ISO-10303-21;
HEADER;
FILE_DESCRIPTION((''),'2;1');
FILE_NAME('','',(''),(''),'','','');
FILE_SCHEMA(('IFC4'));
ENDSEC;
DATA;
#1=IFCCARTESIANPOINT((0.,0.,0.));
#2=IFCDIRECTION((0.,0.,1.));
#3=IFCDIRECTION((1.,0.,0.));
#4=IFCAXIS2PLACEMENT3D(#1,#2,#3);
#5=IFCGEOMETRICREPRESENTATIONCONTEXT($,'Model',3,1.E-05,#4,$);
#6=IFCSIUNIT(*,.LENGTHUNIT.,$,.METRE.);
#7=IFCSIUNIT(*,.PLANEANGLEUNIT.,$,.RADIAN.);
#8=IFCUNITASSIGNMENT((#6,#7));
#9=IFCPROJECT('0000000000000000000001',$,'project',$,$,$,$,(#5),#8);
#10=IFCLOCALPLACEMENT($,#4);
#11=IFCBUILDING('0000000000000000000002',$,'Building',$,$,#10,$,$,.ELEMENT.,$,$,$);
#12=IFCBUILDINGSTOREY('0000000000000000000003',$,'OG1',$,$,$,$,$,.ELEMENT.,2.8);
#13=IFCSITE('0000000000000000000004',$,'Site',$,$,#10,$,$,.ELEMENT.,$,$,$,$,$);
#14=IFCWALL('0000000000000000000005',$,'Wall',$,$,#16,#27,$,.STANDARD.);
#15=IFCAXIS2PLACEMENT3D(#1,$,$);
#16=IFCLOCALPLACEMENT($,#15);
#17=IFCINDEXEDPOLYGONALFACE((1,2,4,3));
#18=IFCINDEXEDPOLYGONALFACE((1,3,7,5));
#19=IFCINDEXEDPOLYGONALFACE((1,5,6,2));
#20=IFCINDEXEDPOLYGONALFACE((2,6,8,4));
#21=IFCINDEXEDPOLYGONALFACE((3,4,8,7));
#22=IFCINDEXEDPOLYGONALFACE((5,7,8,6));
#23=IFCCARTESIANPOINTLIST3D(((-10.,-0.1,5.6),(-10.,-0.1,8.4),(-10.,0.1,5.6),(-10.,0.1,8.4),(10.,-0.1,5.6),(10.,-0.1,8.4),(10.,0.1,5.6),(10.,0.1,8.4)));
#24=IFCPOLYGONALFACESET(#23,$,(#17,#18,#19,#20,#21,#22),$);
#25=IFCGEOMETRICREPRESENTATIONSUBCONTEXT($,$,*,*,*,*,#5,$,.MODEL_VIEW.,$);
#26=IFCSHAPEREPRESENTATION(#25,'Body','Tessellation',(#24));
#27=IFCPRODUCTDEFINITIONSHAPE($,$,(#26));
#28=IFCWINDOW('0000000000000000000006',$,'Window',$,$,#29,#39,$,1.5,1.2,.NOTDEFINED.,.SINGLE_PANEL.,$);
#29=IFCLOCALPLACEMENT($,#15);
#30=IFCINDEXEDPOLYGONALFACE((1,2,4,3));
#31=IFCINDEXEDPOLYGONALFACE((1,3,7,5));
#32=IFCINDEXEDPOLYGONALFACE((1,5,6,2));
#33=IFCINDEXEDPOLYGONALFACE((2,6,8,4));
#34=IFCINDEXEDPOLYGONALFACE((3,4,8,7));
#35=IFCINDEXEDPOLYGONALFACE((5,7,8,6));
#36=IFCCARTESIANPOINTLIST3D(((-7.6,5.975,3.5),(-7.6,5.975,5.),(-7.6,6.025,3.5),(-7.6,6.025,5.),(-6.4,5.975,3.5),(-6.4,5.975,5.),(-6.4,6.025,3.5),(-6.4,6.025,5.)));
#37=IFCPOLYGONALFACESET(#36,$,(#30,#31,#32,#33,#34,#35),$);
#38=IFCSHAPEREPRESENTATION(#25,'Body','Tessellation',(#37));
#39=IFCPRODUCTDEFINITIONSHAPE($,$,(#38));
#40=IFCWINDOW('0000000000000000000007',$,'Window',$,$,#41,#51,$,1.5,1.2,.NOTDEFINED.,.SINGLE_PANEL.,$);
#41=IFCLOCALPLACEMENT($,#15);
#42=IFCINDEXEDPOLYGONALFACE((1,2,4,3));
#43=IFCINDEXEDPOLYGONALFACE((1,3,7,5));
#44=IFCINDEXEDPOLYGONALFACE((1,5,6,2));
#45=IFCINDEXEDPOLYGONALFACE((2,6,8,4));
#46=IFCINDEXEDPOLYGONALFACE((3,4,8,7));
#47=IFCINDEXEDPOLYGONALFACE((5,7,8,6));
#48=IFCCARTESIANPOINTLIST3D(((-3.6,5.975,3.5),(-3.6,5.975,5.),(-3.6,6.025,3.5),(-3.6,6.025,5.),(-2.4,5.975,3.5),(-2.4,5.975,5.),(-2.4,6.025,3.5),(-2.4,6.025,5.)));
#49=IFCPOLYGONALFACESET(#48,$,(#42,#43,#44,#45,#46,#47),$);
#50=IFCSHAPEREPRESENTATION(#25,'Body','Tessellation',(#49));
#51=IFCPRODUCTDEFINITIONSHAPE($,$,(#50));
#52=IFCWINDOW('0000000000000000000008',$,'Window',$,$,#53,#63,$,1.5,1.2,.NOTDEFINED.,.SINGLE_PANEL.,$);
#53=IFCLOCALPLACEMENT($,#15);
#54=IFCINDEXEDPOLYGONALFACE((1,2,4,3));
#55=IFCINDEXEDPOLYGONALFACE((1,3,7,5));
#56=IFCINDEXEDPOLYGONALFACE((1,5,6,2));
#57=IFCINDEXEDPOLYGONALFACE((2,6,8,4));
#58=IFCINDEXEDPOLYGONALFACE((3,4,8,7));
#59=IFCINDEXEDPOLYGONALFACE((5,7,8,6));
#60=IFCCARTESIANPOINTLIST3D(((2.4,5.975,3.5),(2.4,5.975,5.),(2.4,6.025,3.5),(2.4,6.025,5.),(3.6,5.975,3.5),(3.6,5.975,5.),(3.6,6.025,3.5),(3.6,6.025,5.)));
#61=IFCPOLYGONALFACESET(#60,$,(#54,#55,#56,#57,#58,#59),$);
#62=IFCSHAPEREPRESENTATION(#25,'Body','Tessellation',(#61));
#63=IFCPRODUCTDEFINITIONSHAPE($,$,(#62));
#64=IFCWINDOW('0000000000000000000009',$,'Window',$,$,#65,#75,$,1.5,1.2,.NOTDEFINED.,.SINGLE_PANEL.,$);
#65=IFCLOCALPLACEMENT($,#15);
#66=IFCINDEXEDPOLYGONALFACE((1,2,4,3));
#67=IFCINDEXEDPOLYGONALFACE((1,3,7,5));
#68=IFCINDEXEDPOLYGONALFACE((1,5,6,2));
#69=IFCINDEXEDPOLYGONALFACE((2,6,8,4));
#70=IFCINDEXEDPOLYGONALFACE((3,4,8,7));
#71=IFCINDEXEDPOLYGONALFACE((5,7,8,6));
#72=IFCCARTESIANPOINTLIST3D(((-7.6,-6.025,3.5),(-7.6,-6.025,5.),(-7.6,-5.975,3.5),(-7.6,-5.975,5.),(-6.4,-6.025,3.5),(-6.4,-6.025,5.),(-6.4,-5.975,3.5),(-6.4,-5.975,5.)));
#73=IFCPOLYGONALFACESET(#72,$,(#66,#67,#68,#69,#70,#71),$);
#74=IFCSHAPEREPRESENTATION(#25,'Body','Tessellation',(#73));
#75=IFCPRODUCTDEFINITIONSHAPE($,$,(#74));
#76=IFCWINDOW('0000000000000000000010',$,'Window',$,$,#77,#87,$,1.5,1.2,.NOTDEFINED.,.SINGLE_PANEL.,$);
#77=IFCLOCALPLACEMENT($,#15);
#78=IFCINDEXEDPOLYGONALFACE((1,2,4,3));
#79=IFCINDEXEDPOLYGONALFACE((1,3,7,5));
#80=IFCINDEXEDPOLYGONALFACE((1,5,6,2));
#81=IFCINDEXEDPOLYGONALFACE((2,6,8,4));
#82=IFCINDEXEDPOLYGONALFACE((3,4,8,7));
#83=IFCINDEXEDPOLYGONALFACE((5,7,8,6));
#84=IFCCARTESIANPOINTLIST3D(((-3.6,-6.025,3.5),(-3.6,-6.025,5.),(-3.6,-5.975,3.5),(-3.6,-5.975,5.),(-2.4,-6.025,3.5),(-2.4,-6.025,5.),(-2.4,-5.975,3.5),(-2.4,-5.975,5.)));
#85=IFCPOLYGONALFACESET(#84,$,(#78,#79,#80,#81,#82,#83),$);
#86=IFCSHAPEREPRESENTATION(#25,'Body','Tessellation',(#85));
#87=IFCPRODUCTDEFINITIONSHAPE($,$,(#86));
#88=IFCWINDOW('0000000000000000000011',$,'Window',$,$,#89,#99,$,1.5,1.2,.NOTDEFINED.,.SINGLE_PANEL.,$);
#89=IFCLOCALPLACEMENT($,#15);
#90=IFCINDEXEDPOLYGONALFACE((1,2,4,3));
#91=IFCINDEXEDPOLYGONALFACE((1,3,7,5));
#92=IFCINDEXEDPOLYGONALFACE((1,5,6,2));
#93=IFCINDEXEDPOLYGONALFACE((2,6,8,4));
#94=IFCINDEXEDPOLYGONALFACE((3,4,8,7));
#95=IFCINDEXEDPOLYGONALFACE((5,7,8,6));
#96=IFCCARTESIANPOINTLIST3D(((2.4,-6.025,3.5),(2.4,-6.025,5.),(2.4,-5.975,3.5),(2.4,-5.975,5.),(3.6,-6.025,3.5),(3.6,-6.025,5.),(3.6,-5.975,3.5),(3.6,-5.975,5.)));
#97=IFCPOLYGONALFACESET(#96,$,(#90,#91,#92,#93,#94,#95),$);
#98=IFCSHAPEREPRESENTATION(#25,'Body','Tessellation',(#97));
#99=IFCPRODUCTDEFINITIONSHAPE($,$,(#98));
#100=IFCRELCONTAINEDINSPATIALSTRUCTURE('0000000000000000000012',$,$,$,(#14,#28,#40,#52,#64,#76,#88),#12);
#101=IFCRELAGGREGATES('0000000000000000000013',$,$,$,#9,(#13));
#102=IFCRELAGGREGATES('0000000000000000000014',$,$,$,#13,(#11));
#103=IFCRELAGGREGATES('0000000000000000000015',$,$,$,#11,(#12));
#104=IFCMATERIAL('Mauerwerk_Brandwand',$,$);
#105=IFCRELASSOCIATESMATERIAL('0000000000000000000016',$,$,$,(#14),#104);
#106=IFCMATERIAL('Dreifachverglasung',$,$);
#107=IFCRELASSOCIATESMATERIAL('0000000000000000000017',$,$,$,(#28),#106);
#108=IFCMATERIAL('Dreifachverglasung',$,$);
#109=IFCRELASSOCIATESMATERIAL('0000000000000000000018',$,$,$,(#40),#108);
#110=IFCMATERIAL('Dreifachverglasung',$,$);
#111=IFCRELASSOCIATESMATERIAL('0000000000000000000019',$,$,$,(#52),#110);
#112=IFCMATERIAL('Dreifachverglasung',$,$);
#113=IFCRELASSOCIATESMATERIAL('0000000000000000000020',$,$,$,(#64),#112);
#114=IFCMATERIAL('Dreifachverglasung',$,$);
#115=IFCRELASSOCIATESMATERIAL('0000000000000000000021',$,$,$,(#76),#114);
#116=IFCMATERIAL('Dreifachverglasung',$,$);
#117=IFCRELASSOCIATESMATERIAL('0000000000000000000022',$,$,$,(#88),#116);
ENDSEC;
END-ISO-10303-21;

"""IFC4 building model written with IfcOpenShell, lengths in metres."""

from ifc_helpers import new_model, si_unit, frame, frame_2d, origin, origin_with_axes, origin_2d, place, context, subcontext, project, spatial, rectangle, extrude, material, element, save


model = new_model("IFC4")

# Units and contexts
model_context = context("Model", 3, precision=1e-05, world=origin_with_axes())
sub_context = subcontext(model_context, None, None, "MODEL_VIEW")
ifc_project = project(units=[si_unit("LENGTHUNIT", "METRE"), si_unit("PLANEANGLEUNIT", "RADIAN")], contexts=[model_context])

# Site, building, storey
placement_1 = place(None, origin_with_axes())
site = spatial("IfcSite", under=ifc_project, at=placement_1, Name="Site", CompositionType="ELEMENT")
building = spatial("IfcBuilding", under=site, at=placement_1, Name="Building", CompositionType="ELEMENT")
storey = spatial("IfcBuildingStorey", under=building, Name="OG1", CompositionType="ELEMENT", Elevation=2.8)

# Wall
ifc_material_1 = material(Name="Mauerwerk_Brandwand")
placement_2 = place(None, origin_with_axes())
placement_3 = place(placement_2, frame((0.0, 0.0, 2.8)))
wall_1_placement = place(placement_3, frame((-10.0, 0.0, 2.8), x_axis=(1.0, 0.0, 0.0)))
element("IfcWall", 1, at=wall_1_placement, inside=storey, material=ifc_material_1, Name="Wall", PredefinedType="STANDARD", context=sub_context, shape_type="SweptSolid", body=[
    extrude(rectangle(XDim=20.0, YDim=0.2, at=frame_2d((10.0, 0.0))), origin(), (0.0, 0.0, 1.0), 2.8),
])

# Windows
ifc_material_2 = material(Name="Dreifachverglasung")
placement_4 = place(None, origin_with_axes())
window_1_placement = place(placement_4, frame((-7.0, 6.0, 3.5)))
element("IfcWindow", 2, at=window_1_placement, inside=storey, material=ifc_material_2, Name="Window", OverallHeight=1.5, OverallWidth=1.2, PartitioningType="SINGLE_PANEL", PredefinedType="NOTDEFINED", context=sub_context, shape_type="SweptSolid", body=[
    extrude(rectangle(XDim=1.2, YDim=0.05, at=origin_2d()), origin(), (0.0, 0.0, 1.0), 1.5),
])
ifc_material_3 = material(Name="Dreifachverglasung")
placement_5 = place(None, origin_with_axes())
window_2_placement = place(placement_5, frame((-3.0, 6.0, 3.5)))
element("IfcWindow", 3, at=window_2_placement, inside=storey, material=ifc_material_3, Name="Window", OverallHeight=1.5, OverallWidth=1.2, PartitioningType="SINGLE_PANEL", PredefinedType="NOTDEFINED", context=sub_context, shape_type="SweptSolid", body=[
    extrude(rectangle(XDim=1.2, YDim=0.05, at=origin_2d()), origin(), (0.0, 0.0, 1.0), 1.5),
])
ifc_material_4 = material(Name="Dreifachverglasung")
placement_6 = place(None, origin_with_axes())
window_3_placement = place(placement_6, frame((3.0, 6.0, 3.5)))
element("IfcWindow", 4, at=window_3_placement, inside=storey, material=ifc_material_4, Name="Window", OverallHeight=1.5, OverallWidth=1.2, PartitioningType="SINGLE_PANEL", PredefinedType="NOTDEFINED", context=sub_context, shape_type="SweptSolid", body=[
    extrude(rectangle(XDim=1.2, YDim=0.05, at=origin_2d()), origin(), (0.0, 0.0, 1.0), 1.5),
])
ifc_material_5 = material(Name="Dreifachverglasung")
placement_7 = place(None, origin_with_axes())
window_4_placement = place(placement_7, frame((-7.0, -6.0, 3.5)))
element("IfcWindow", 5, at=window_4_placement, inside=storey, material=ifc_material_5, Name="Window", OverallHeight=1.5, OverallWidth=1.2, PartitioningType="SINGLE_PANEL", PredefinedType="NOTDEFINED", context=sub_context, shape_type="SweptSolid", body=[
    extrude(rectangle(XDim=1.2, YDim=0.05, at=origin_2d()), origin(), (0.0, 0.0, 1.0), 1.5),
])
ifc_material_6 = material(Name="Dreifachverglasung")
placement_8 = place(None, origin_with_axes())
window_5_placement = place(placement_8, frame((-3.0, -6.0, 3.5)))
element("IfcWindow", 6, at=window_5_placement, inside=storey, material=ifc_material_6, Name="Window", OverallHeight=1.5, OverallWidth=1.2, PartitioningType="SINGLE_PANEL", PredefinedType="NOTDEFINED", context=sub_context, shape_type="SweptSolid", body=[
    extrude(rectangle(XDim=1.2, YDim=0.05, at=origin_2d()), origin(), (0.0, 0.0, 1.0), 1.5),
])
ifc_material_7 = material(Name="Dreifachverglasung")
placement_9 = place(None, origin_with_axes())
window_6_placement = place(placement_9, frame((3.0, -6.0, 3.5)))
element("IfcWindow", 7, at=window_6_placement, inside=storey, material=ifc_material_7, Name="Window", OverallHeight=1.5, OverallWidth=1.2, PartitioningType="SINGLE_PANEL", PredefinedType="NOTDEFINED", context=sub_context, shape_type="SweptSolid", body=[
    extrude(rectangle(XDim=1.2, YDim=0.05, at=origin_2d()), origin(), (0.0, 0.0, 1.0), 1.5),
])

save(model, "model.ifc")
